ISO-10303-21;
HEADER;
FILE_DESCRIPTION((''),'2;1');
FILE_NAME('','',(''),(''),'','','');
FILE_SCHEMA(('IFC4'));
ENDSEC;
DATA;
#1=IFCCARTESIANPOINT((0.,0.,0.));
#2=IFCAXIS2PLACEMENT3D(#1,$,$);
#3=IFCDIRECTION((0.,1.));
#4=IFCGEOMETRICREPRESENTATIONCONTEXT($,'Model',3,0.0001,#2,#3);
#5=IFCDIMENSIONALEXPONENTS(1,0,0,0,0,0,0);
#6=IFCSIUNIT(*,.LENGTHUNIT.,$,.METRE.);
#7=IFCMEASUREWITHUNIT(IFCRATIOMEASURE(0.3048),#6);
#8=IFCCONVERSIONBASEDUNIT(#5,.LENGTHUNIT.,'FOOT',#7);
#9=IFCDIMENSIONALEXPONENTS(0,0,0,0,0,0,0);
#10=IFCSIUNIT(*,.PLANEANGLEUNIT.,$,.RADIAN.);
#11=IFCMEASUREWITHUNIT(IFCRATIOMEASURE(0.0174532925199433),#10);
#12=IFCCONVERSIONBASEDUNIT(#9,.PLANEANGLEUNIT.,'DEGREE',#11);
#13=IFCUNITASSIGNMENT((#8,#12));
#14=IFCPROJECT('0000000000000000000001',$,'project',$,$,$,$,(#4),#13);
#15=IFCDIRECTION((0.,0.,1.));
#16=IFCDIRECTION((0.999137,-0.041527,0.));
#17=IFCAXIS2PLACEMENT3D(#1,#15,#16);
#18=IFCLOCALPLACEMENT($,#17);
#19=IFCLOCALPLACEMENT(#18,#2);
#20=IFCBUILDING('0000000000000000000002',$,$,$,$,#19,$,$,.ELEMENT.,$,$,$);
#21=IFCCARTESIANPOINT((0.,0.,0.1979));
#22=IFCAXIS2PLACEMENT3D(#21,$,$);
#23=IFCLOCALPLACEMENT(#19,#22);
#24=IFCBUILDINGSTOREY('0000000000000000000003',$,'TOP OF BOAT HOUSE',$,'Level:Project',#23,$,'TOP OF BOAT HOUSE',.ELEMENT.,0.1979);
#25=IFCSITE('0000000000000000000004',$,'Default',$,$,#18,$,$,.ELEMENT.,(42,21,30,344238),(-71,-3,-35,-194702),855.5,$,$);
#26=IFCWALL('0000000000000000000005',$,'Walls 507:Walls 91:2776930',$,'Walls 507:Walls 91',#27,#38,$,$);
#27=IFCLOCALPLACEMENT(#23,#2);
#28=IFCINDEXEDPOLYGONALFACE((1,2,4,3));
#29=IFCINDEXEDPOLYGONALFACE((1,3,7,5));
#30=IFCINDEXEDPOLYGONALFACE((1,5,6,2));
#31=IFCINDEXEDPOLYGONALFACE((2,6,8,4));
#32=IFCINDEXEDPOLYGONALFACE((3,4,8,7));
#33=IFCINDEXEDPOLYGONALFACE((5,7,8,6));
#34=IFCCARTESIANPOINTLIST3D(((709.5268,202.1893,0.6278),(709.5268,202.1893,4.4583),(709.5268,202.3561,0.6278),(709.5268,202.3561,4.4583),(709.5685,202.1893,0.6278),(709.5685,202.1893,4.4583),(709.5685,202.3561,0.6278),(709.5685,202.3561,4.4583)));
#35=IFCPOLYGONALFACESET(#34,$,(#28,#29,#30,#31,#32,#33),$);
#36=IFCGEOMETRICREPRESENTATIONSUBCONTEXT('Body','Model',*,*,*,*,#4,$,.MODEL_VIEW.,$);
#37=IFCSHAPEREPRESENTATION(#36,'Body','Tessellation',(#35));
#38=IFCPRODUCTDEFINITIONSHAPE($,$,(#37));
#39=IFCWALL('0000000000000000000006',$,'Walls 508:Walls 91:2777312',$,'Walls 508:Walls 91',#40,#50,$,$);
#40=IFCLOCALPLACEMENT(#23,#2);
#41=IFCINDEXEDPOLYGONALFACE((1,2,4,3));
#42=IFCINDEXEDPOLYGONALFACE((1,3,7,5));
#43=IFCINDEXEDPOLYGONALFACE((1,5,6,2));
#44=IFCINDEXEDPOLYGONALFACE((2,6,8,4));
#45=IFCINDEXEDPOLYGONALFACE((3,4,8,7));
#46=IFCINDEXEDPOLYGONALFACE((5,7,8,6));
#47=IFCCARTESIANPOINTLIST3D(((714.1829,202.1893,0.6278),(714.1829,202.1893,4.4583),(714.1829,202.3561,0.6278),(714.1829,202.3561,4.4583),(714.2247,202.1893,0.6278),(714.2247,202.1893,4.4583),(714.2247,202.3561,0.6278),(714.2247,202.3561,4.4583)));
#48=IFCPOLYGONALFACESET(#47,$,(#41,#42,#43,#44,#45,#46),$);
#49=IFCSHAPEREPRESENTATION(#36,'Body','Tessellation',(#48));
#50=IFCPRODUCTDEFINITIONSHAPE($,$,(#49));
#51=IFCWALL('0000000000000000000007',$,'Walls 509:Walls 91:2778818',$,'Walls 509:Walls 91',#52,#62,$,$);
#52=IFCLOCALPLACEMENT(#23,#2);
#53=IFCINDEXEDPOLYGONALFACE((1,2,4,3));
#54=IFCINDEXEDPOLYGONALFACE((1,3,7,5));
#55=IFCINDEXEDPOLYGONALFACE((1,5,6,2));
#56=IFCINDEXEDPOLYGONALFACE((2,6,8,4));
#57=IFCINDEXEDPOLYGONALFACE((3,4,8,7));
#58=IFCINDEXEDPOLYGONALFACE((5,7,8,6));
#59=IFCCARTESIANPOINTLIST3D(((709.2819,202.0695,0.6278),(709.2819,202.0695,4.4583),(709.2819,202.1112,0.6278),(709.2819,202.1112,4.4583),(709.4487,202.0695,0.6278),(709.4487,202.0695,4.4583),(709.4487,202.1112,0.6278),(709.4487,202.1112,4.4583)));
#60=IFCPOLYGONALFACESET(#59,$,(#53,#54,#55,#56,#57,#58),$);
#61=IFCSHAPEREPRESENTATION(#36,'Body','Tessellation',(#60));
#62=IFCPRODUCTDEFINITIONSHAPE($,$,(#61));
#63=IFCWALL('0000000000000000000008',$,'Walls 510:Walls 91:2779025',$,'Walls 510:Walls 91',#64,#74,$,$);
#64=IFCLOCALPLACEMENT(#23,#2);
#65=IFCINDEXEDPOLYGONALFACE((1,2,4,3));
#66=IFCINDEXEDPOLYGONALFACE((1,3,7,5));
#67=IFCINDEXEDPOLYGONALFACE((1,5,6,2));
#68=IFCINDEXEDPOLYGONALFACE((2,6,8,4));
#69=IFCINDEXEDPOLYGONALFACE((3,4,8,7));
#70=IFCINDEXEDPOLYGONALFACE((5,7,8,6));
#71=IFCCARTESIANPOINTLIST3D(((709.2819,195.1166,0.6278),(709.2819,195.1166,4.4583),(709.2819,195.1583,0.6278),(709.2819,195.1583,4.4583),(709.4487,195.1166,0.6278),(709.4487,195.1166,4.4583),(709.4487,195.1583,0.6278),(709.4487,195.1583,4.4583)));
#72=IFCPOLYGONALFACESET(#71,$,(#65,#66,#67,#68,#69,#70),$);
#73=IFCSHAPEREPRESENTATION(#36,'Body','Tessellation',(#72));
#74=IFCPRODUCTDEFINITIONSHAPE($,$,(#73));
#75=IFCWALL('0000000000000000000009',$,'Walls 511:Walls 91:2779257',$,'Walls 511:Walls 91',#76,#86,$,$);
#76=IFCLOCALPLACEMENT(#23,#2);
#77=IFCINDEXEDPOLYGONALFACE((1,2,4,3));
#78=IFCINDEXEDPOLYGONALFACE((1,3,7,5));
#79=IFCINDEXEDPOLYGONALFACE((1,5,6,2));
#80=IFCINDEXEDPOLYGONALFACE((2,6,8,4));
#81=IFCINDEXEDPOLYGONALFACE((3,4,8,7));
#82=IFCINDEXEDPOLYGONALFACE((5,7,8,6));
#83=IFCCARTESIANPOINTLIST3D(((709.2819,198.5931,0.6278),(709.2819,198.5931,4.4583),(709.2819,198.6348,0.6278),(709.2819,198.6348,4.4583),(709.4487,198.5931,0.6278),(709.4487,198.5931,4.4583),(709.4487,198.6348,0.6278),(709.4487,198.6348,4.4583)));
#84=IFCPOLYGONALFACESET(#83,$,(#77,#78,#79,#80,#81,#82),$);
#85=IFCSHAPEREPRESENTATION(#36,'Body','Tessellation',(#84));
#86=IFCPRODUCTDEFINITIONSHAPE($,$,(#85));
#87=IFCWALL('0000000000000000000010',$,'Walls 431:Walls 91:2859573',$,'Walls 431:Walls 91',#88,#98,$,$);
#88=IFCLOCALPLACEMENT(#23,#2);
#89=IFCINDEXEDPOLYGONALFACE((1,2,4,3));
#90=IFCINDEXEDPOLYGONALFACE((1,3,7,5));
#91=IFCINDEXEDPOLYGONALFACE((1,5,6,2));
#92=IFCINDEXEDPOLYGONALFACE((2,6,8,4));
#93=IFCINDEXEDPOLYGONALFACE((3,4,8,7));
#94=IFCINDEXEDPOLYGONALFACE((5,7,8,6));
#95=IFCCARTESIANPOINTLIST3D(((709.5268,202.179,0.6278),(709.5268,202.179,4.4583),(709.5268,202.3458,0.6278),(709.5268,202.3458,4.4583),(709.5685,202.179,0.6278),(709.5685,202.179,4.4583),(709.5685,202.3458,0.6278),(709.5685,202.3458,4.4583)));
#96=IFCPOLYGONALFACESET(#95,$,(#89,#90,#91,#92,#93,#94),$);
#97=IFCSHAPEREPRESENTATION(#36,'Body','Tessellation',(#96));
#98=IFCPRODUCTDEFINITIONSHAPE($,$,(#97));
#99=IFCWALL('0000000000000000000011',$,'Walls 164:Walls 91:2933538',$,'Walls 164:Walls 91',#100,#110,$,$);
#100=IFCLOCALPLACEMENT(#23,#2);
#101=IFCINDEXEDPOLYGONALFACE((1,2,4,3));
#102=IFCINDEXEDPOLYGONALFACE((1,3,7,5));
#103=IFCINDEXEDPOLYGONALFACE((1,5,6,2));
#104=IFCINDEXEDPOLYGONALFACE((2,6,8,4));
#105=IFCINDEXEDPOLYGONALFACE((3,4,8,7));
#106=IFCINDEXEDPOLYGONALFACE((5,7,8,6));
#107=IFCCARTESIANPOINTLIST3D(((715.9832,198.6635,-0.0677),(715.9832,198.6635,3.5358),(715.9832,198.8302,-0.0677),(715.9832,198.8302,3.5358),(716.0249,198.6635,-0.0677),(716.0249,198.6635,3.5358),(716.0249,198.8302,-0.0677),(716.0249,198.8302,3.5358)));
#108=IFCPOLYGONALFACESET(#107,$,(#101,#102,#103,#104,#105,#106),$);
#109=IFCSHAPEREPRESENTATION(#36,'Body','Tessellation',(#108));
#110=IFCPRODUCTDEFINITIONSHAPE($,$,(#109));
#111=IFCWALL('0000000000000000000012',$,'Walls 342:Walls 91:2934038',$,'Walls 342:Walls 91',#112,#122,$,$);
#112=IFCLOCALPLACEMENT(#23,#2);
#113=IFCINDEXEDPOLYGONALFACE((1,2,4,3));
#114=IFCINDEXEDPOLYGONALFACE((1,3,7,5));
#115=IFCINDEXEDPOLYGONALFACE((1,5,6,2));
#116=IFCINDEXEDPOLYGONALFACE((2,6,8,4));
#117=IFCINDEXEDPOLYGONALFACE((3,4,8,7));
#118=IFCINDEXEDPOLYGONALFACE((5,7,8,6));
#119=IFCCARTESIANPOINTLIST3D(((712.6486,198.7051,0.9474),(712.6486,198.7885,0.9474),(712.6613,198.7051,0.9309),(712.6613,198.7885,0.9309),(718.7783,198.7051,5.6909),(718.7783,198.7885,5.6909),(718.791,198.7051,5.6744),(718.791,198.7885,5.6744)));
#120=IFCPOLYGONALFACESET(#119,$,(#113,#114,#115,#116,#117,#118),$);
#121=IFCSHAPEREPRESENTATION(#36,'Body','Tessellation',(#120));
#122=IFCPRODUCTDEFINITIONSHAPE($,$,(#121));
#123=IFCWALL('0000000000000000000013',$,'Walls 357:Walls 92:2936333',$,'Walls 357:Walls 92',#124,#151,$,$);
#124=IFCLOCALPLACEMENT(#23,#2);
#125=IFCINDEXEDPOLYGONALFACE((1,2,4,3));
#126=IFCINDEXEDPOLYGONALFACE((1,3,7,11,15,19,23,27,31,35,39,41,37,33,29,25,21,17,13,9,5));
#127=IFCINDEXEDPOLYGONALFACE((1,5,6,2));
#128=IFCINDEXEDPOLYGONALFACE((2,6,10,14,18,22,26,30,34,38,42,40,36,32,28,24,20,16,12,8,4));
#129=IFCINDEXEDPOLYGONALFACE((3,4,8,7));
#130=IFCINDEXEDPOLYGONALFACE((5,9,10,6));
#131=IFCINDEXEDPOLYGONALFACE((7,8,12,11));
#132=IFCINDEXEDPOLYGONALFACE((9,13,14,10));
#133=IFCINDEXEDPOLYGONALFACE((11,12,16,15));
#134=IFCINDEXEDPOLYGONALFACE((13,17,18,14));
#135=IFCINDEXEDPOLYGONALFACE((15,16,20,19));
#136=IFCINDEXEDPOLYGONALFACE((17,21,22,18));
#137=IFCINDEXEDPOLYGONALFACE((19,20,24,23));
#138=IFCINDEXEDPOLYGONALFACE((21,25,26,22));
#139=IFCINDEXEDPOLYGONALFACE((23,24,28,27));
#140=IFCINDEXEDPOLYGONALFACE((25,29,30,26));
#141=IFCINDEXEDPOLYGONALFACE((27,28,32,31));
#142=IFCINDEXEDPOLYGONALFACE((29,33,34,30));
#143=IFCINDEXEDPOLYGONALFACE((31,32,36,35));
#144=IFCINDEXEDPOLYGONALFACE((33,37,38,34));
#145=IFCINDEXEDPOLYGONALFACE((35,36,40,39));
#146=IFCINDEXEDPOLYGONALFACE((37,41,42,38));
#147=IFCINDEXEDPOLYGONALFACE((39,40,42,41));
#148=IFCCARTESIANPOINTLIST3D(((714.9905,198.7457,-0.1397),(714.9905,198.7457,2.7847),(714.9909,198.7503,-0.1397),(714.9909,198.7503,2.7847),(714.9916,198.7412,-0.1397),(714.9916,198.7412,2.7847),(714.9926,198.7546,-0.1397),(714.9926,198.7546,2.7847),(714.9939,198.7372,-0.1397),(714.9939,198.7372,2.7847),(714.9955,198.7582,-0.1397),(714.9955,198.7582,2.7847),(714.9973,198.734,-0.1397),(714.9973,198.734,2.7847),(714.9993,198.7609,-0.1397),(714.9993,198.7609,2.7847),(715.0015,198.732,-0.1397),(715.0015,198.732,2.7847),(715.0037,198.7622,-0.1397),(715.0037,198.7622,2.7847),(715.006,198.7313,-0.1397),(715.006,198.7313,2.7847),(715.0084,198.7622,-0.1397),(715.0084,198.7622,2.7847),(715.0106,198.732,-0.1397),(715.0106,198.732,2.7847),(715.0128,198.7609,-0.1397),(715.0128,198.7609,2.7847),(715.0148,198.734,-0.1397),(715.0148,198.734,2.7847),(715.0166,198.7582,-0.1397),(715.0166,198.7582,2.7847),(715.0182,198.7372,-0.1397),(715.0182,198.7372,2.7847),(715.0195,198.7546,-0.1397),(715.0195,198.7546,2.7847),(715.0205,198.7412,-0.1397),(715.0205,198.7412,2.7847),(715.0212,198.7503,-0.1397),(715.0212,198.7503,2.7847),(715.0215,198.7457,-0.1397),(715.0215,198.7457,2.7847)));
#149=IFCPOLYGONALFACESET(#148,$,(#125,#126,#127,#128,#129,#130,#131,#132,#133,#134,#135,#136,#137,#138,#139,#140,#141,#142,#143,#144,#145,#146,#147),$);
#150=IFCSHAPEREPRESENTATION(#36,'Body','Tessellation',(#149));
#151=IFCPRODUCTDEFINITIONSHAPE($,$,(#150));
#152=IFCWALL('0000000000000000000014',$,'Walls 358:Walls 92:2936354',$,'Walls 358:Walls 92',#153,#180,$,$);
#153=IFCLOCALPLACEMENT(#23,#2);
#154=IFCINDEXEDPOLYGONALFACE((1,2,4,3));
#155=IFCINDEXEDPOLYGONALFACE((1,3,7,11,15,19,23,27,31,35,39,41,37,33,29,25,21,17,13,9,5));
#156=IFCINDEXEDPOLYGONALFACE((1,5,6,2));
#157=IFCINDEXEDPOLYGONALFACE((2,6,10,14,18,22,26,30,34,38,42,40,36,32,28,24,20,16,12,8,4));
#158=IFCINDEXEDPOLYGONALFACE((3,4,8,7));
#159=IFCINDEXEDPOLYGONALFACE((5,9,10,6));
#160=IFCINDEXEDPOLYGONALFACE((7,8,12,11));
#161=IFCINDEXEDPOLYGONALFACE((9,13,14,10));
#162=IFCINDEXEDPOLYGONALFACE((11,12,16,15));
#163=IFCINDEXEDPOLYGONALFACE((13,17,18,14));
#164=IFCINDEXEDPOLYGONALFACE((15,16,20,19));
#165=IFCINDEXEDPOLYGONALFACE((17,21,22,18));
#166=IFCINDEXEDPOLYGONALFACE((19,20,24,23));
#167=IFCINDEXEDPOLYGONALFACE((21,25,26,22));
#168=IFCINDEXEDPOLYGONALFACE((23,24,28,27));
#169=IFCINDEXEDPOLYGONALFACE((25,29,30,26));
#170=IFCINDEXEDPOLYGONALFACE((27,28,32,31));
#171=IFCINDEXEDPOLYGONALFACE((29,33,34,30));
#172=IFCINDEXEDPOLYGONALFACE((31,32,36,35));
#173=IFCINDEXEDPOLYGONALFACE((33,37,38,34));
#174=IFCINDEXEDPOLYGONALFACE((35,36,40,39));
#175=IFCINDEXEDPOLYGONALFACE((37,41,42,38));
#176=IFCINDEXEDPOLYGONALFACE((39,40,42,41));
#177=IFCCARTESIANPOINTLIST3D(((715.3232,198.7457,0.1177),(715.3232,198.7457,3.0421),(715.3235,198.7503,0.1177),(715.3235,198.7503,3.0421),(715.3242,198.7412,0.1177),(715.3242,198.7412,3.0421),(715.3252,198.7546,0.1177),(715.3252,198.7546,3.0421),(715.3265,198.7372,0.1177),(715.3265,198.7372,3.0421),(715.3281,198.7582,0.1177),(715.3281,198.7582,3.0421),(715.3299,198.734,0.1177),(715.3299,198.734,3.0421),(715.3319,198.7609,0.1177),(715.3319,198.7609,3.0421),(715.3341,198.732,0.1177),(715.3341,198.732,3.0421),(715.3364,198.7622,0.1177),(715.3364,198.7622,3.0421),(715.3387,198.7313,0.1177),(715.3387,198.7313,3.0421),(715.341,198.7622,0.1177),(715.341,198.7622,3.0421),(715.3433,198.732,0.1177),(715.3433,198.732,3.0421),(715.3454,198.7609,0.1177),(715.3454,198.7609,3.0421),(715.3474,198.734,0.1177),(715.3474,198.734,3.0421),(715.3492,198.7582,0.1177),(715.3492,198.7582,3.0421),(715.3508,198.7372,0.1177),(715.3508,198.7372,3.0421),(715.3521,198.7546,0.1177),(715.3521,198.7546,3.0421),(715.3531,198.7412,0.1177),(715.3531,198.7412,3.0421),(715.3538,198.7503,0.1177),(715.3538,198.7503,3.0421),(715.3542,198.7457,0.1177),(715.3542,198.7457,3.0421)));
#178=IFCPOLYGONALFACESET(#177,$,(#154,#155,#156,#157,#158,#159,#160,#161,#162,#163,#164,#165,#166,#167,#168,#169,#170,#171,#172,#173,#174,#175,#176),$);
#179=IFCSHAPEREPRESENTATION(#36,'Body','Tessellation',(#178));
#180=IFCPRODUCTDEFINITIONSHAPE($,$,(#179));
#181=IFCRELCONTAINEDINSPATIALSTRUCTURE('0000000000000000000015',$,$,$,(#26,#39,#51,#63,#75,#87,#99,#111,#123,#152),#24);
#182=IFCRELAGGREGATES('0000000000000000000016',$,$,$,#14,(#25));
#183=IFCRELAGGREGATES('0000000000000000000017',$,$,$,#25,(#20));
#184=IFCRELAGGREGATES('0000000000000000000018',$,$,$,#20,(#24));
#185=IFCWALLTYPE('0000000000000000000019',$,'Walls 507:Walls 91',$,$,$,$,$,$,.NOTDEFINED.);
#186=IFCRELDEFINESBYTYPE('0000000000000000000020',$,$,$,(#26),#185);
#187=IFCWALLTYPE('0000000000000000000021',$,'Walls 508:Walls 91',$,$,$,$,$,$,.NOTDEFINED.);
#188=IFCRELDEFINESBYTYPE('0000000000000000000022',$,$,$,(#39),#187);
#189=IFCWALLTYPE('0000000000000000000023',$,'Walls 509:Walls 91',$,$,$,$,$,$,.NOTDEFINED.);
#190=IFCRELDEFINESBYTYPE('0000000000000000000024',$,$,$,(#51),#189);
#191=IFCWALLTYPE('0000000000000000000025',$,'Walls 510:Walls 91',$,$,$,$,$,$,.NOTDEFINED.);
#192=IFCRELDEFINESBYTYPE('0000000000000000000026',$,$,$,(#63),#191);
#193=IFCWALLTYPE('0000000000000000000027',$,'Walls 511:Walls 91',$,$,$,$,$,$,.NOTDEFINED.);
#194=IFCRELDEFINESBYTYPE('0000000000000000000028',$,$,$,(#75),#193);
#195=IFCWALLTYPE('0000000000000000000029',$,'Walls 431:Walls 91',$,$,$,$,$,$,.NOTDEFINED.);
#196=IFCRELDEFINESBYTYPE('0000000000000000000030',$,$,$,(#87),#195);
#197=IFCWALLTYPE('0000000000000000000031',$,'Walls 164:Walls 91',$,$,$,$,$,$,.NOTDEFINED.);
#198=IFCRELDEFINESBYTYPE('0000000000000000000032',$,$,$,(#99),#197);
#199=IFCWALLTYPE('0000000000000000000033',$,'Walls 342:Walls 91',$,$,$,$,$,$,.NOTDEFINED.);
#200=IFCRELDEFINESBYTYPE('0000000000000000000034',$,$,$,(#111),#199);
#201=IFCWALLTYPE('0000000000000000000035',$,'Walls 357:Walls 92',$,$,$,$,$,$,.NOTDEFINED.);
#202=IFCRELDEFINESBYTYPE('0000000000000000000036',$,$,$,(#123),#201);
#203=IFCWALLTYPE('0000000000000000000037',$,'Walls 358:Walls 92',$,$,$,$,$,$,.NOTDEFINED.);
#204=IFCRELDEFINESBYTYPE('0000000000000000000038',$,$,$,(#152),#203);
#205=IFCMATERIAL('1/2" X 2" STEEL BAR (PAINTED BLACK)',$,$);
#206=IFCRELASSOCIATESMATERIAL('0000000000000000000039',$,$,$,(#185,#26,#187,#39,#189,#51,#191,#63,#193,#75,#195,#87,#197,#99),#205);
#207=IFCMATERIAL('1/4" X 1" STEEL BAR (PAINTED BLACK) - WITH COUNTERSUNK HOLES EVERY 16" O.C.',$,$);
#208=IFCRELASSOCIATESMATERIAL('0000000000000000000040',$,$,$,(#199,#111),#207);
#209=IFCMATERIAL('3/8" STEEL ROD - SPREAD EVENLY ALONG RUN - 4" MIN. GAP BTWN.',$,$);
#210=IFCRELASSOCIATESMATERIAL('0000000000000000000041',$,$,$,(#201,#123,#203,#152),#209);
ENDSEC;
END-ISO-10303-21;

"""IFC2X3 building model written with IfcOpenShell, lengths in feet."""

from ifc_helpers import new_model, entity, si_unit, converted_unit, direction, frame, frame_2d, origin, origin_2d_with_axis, place, context, subcontext, project, spatial, rectangle, circle, extrude, material, type_object, element, save


model = new_model("IFC2X3")

# Units and contexts
model_context = context("Model", 3, precision=0.0001, world=origin(), true_north=direction((0.0, 1.0)))
body_context = subcontext(model_context, "Body", "Model", "MODEL_VIEW")
ifc_project = project(units=[converted_unit("LENGTHUNIT", "FOOT", entity("IfcRatioMeasure", 0.3048), si_unit("LENGTHUNIT", "METRE"), dimensions=[1, 0, 0, 0, 0, 0, 0]), converted_unit("PLANEANGLEUNIT", "DEGREE", entity("IfcRatioMeasure", 0.0174532925199433), si_unit("PLANEANGLEUNIT", "RADIAN"), dimensions=[0, 0, 0, 0, 0, 0, 0])], contexts=[model_context])

# Site, building, storey
site_placement = place(None, frame((0.0, 0.0, 0.0), z_axis=(0.0, 0.0, 1.0), x_axis=(0.999137, -0.041527, 0.0)))
site = spatial("IfcSite", under=ifc_project, at=site_placement, Name="Default", CompositionType="ELEMENT", RefLatitude=(42, 21, 30, 344238), RefLongitude=(-71, -3, -35, -194702), RefElevation=855.5)
building_placement = place(site_placement, origin())
building = spatial("IfcBuilding", under=site, at=building_placement, CompositionType="ELEMENT")
storey_placement = place(building_placement, frame((0.0, 0.0, 0.1979)))
storey = spatial("IfcBuildingStorey", under=building, at=storey_placement, Name="TOP OF BOAT HOUSE", ObjectType="Level:Project", LongName="TOP OF BOAT HOUSE", CompositionType="ELEMENT", Elevation=0.1979)

# Walls
ifc_material_1 = material(Name="1/2\" X 2\" STEEL BAR (PAINTED BLACK)")
wall_type_1 = type_object("IfcWallType", Name="Walls 507:Walls 91", PredefinedType="NOTDEFINED", material=ifc_material_1)
wall_1_placement = place(storey_placement, frame((709.5268, 202.1893, 0.6278), z_axis=(0.0, 0.0, 1.0), x_axis=(0.0, 1.0, 0.0)))
element("IfcWall", 1, at=wall_1_placement, inside=storey, type_object=wall_type_1, material=ifc_material_1, Name="Walls 507:Walls 91:2776930", ObjectType="Walls 507:Walls 91", context=body_context, shape_type="SweptSolid", body=[
    extrude(rectangle(XDim=0.1667, YDim=0.0417, at=frame_2d((0.0, 0.0), x_axis=(1.0, 0.0))), frame((0.0834, -0.0209, 0.0)), (0.0, 0.0, 1.0), 3.8305),
])
wall_type_2 = type_object("IfcWallType", Name="Walls 508:Walls 91", PredefinedType="NOTDEFINED", material=ifc_material_1)
wall_2_placement = place(storey_placement, frame((714.1829, 202.1893, 0.6278), z_axis=(0.0, 0.0, 1.0), x_axis=(0.0, 1.0, 0.0)))
element("IfcWall", 2, at=wall_2_placement, inside=storey, type_object=wall_type_2, material=ifc_material_1, Name="Walls 508:Walls 91:2777312", ObjectType="Walls 508:Walls 91", context=body_context, shape_type="SweptSolid", body=[
    extrude(rectangle(XDim=0.1667, YDim=0.0417, at=frame_2d((0.0, 0.0), x_axis=(1.0, 0.0))), frame((0.0834, -0.0209, 0.0)), (0.0, 0.0, 1.0), 3.8305),
])
wall_type_3 = type_object("IfcWallType", Name="Walls 509:Walls 91", PredefinedType="NOTDEFINED", material=ifc_material_1)
wall_3_placement = place(storey_placement, frame((709.2819, 202.0695, 0.6278)))
element("IfcWall", 3, at=wall_3_placement, inside=storey, type_object=wall_type_3, material=ifc_material_1, Name="Walls 509:Walls 91:2778818", ObjectType="Walls 509:Walls 91", context=body_context, shape_type="SweptSolid", body=[
    extrude(rectangle(XDim=0.0417, YDim=0.1667, at=frame_2d((0.0, 0.0), x_axis=(1.0, 0.0))), frame((0.0834, 0.0209, 0.0), z_axis=(0.0, 0.0, 1.0), x_axis=(0.0, 1.0, 0.0)), (0.0, 0.0, 1.0), 3.8305),
])
wall_type_4 = type_object("IfcWallType", Name="Walls 510:Walls 91", PredefinedType="NOTDEFINED", material=ifc_material_1)
wall_4_placement = place(storey_placement, frame((709.2819, 195.1166, 0.6278)))
element("IfcWall", 4, at=wall_4_placement, inside=storey, type_object=wall_type_4, material=ifc_material_1, Name="Walls 510:Walls 91:2779025", ObjectType="Walls 510:Walls 91", context=body_context, shape_type="SweptSolid", body=[
    extrude(rectangle(XDim=0.1667, YDim=0.0417, at=origin_2d_with_axis()), frame((0.0834, 0.0209, 0.0), z_axis=(0.0, 0.0, 1.0), x_axis=(-1.0, 0.0, 0.0)), (0.0, 0.0, 1.0), 3.8305),
])
wall_type_5 = type_object("IfcWallType", Name="Walls 511:Walls 91", PredefinedType="NOTDEFINED", material=ifc_material_1)
wall_5_placement = place(storey_placement, frame((709.2819, 198.5931, 0.6278)))
element("IfcWall", 5, at=wall_5_placement, inside=storey, type_object=wall_type_5, material=ifc_material_1, Name="Walls 511:Walls 91:2779257", ObjectType="Walls 511:Walls 91", context=body_context, shape_type="SweptSolid", body=[
    extrude(rectangle(XDim=0.1667, YDim=0.0417, at=origin_2d_with_axis()), frame((0.0834, 0.0209, 0.0), z_axis=(0.0, 0.0, 1.0), x_axis=(-1.0, 0.0, 0.0)), (0.0, 0.0, 1.0), 3.8305),
])
wall_type_6 = type_object("IfcWallType", Name="Walls 431:Walls 91", PredefinedType="NOTDEFINED", material=ifc_material_1)
wall_6_placement = place(storey_placement, frame((709.5268, 202.179, 0.6278), z_axis=(0.0, 0.0, 1.0), x_axis=(0.0, 1.0, 0.0)))
element("IfcWall", 6, at=wall_6_placement, inside=storey, type_object=wall_type_6, material=ifc_material_1, Name="Walls 431:Walls 91:2859573", ObjectType="Walls 431:Walls 91", context=body_context, shape_type="SweptSolid", body=[
    extrude(rectangle(XDim=0.1667, YDim=0.0417, at=frame_2d((0.0, 0.0), x_axis=(1.0, 0.0))), frame((0.0834, -0.0209, 0.0)), (0.0, 0.0, 1.0), 3.8305),
])
wall_type_7 = type_object("IfcWallType", Name="Walls 164:Walls 91", PredefinedType="NOTDEFINED", material=ifc_material_1)
wall_7_placement = place(storey_placement, frame((715.9832, 198.6635, -0.0677), z_axis=(0.0, 0.0, 1.0), x_axis=(0.0, 1.0, 0.0)))
element("IfcWall", 7, at=wall_7_placement, inside=storey, type_object=wall_type_7, material=ifc_material_1, Name="Walls 164:Walls 91:2933538", ObjectType="Walls 164:Walls 91", context=body_context, shape_type="SweptSolid", body=[
    extrude(rectangle(XDim=0.1667, YDim=0.0417, at=frame_2d((0.0, 0.0), x_axis=(1.0, 0.0))), frame((0.0834, -0.0209, 0.0)), (0.0, 0.0, 1.0), 3.6035),
])
ifc_material_2 = material(Name="1/4\" X 1\" STEEL BAR (PAINTED BLACK) - WITH COUNTERSUNK HOLES EVERY 16\" O.C.")
wall_type_8 = type_object("IfcWallType", Name="Walls 342:Walls 91", PredefinedType="NOTDEFINED", material=ifc_material_2)
wall_8_placement = place(storey_placement, frame((712.6486, 198.7051, 0.9309)))
element("IfcWall", 8, at=wall_8_placement, inside=storey, type_object=wall_type_8, material=ifc_material_2, Name="Walls 342:Walls 91:2934038", ObjectType="Walls 342:Walls 91", context=body_context, shape_type="SweptSolid", body=[
    extrude(rectangle(XDim=7.7508, YDim=0.0833, at=frame_2d((0.0, 0.0), x_axis=(1.0, 0.0))), frame((3.0776, 0.0417, 2.3718), z_axis=(-0.612008, 0.0, 0.790852), x_axis=(0.790852, 0.0, 0.612008)), (0.0, 0.0, 1.0), 0.0208),
])
ifc_material_3 = material(Name="3/8\" STEEL ROD - SPREAD EVENLY ALONG RUN - 4\" MIN. GAP BTWN.")
wall_type_9 = type_object("IfcWallType", Name="Walls 357:Walls 92", PredefinedType="NOTDEFINED", material=ifc_material_3)
wall_9_placement = place(storey_placement, frame((714.9905, 198.7313, -0.1397)))
element("IfcWall", 9, at=wall_9_placement, inside=storey, type_object=wall_type_9, material=ifc_material_3, Name="Walls 357:Walls 92:2936333", ObjectType="Walls 357:Walls 92", context=body_context, shape_type="SweptSolid", body=[
    extrude(circle(Radius=0.0155, at=origin_2d_with_axis()), frame((0.0155, 0.0155, 0.0), z_axis=(0.0, 0.0, 1.0), x_axis=(0.0, -1.0, 0.0)), (0.0, 0.0, 1.0), 2.9244),
])
wall_type_10 = type_object("IfcWallType", Name="Walls 358:Walls 92", PredefinedType="NOTDEFINED", material=ifc_material_3)
wall_10_placement = place(storey_placement, frame((715.3231, 198.7313, 0.1177)))
element("IfcWall", 10, at=wall_10_placement, inside=storey, type_object=wall_type_10, material=ifc_material_3, Name="Walls 358:Walls 92:2936354", ObjectType="Walls 358:Walls 92", context=body_context, shape_type="SweptSolid", body=[
    extrude(circle(Radius=0.0155, at=origin_2d_with_axis()), frame((0.0155, 0.0155, 0.0), z_axis=(0.0, 0.0, 1.0), x_axis=(0.0, -1.0, 0.0)), (0.0, 0.0, 1.0), 2.9244),
])

save(model, "model.ifc")
